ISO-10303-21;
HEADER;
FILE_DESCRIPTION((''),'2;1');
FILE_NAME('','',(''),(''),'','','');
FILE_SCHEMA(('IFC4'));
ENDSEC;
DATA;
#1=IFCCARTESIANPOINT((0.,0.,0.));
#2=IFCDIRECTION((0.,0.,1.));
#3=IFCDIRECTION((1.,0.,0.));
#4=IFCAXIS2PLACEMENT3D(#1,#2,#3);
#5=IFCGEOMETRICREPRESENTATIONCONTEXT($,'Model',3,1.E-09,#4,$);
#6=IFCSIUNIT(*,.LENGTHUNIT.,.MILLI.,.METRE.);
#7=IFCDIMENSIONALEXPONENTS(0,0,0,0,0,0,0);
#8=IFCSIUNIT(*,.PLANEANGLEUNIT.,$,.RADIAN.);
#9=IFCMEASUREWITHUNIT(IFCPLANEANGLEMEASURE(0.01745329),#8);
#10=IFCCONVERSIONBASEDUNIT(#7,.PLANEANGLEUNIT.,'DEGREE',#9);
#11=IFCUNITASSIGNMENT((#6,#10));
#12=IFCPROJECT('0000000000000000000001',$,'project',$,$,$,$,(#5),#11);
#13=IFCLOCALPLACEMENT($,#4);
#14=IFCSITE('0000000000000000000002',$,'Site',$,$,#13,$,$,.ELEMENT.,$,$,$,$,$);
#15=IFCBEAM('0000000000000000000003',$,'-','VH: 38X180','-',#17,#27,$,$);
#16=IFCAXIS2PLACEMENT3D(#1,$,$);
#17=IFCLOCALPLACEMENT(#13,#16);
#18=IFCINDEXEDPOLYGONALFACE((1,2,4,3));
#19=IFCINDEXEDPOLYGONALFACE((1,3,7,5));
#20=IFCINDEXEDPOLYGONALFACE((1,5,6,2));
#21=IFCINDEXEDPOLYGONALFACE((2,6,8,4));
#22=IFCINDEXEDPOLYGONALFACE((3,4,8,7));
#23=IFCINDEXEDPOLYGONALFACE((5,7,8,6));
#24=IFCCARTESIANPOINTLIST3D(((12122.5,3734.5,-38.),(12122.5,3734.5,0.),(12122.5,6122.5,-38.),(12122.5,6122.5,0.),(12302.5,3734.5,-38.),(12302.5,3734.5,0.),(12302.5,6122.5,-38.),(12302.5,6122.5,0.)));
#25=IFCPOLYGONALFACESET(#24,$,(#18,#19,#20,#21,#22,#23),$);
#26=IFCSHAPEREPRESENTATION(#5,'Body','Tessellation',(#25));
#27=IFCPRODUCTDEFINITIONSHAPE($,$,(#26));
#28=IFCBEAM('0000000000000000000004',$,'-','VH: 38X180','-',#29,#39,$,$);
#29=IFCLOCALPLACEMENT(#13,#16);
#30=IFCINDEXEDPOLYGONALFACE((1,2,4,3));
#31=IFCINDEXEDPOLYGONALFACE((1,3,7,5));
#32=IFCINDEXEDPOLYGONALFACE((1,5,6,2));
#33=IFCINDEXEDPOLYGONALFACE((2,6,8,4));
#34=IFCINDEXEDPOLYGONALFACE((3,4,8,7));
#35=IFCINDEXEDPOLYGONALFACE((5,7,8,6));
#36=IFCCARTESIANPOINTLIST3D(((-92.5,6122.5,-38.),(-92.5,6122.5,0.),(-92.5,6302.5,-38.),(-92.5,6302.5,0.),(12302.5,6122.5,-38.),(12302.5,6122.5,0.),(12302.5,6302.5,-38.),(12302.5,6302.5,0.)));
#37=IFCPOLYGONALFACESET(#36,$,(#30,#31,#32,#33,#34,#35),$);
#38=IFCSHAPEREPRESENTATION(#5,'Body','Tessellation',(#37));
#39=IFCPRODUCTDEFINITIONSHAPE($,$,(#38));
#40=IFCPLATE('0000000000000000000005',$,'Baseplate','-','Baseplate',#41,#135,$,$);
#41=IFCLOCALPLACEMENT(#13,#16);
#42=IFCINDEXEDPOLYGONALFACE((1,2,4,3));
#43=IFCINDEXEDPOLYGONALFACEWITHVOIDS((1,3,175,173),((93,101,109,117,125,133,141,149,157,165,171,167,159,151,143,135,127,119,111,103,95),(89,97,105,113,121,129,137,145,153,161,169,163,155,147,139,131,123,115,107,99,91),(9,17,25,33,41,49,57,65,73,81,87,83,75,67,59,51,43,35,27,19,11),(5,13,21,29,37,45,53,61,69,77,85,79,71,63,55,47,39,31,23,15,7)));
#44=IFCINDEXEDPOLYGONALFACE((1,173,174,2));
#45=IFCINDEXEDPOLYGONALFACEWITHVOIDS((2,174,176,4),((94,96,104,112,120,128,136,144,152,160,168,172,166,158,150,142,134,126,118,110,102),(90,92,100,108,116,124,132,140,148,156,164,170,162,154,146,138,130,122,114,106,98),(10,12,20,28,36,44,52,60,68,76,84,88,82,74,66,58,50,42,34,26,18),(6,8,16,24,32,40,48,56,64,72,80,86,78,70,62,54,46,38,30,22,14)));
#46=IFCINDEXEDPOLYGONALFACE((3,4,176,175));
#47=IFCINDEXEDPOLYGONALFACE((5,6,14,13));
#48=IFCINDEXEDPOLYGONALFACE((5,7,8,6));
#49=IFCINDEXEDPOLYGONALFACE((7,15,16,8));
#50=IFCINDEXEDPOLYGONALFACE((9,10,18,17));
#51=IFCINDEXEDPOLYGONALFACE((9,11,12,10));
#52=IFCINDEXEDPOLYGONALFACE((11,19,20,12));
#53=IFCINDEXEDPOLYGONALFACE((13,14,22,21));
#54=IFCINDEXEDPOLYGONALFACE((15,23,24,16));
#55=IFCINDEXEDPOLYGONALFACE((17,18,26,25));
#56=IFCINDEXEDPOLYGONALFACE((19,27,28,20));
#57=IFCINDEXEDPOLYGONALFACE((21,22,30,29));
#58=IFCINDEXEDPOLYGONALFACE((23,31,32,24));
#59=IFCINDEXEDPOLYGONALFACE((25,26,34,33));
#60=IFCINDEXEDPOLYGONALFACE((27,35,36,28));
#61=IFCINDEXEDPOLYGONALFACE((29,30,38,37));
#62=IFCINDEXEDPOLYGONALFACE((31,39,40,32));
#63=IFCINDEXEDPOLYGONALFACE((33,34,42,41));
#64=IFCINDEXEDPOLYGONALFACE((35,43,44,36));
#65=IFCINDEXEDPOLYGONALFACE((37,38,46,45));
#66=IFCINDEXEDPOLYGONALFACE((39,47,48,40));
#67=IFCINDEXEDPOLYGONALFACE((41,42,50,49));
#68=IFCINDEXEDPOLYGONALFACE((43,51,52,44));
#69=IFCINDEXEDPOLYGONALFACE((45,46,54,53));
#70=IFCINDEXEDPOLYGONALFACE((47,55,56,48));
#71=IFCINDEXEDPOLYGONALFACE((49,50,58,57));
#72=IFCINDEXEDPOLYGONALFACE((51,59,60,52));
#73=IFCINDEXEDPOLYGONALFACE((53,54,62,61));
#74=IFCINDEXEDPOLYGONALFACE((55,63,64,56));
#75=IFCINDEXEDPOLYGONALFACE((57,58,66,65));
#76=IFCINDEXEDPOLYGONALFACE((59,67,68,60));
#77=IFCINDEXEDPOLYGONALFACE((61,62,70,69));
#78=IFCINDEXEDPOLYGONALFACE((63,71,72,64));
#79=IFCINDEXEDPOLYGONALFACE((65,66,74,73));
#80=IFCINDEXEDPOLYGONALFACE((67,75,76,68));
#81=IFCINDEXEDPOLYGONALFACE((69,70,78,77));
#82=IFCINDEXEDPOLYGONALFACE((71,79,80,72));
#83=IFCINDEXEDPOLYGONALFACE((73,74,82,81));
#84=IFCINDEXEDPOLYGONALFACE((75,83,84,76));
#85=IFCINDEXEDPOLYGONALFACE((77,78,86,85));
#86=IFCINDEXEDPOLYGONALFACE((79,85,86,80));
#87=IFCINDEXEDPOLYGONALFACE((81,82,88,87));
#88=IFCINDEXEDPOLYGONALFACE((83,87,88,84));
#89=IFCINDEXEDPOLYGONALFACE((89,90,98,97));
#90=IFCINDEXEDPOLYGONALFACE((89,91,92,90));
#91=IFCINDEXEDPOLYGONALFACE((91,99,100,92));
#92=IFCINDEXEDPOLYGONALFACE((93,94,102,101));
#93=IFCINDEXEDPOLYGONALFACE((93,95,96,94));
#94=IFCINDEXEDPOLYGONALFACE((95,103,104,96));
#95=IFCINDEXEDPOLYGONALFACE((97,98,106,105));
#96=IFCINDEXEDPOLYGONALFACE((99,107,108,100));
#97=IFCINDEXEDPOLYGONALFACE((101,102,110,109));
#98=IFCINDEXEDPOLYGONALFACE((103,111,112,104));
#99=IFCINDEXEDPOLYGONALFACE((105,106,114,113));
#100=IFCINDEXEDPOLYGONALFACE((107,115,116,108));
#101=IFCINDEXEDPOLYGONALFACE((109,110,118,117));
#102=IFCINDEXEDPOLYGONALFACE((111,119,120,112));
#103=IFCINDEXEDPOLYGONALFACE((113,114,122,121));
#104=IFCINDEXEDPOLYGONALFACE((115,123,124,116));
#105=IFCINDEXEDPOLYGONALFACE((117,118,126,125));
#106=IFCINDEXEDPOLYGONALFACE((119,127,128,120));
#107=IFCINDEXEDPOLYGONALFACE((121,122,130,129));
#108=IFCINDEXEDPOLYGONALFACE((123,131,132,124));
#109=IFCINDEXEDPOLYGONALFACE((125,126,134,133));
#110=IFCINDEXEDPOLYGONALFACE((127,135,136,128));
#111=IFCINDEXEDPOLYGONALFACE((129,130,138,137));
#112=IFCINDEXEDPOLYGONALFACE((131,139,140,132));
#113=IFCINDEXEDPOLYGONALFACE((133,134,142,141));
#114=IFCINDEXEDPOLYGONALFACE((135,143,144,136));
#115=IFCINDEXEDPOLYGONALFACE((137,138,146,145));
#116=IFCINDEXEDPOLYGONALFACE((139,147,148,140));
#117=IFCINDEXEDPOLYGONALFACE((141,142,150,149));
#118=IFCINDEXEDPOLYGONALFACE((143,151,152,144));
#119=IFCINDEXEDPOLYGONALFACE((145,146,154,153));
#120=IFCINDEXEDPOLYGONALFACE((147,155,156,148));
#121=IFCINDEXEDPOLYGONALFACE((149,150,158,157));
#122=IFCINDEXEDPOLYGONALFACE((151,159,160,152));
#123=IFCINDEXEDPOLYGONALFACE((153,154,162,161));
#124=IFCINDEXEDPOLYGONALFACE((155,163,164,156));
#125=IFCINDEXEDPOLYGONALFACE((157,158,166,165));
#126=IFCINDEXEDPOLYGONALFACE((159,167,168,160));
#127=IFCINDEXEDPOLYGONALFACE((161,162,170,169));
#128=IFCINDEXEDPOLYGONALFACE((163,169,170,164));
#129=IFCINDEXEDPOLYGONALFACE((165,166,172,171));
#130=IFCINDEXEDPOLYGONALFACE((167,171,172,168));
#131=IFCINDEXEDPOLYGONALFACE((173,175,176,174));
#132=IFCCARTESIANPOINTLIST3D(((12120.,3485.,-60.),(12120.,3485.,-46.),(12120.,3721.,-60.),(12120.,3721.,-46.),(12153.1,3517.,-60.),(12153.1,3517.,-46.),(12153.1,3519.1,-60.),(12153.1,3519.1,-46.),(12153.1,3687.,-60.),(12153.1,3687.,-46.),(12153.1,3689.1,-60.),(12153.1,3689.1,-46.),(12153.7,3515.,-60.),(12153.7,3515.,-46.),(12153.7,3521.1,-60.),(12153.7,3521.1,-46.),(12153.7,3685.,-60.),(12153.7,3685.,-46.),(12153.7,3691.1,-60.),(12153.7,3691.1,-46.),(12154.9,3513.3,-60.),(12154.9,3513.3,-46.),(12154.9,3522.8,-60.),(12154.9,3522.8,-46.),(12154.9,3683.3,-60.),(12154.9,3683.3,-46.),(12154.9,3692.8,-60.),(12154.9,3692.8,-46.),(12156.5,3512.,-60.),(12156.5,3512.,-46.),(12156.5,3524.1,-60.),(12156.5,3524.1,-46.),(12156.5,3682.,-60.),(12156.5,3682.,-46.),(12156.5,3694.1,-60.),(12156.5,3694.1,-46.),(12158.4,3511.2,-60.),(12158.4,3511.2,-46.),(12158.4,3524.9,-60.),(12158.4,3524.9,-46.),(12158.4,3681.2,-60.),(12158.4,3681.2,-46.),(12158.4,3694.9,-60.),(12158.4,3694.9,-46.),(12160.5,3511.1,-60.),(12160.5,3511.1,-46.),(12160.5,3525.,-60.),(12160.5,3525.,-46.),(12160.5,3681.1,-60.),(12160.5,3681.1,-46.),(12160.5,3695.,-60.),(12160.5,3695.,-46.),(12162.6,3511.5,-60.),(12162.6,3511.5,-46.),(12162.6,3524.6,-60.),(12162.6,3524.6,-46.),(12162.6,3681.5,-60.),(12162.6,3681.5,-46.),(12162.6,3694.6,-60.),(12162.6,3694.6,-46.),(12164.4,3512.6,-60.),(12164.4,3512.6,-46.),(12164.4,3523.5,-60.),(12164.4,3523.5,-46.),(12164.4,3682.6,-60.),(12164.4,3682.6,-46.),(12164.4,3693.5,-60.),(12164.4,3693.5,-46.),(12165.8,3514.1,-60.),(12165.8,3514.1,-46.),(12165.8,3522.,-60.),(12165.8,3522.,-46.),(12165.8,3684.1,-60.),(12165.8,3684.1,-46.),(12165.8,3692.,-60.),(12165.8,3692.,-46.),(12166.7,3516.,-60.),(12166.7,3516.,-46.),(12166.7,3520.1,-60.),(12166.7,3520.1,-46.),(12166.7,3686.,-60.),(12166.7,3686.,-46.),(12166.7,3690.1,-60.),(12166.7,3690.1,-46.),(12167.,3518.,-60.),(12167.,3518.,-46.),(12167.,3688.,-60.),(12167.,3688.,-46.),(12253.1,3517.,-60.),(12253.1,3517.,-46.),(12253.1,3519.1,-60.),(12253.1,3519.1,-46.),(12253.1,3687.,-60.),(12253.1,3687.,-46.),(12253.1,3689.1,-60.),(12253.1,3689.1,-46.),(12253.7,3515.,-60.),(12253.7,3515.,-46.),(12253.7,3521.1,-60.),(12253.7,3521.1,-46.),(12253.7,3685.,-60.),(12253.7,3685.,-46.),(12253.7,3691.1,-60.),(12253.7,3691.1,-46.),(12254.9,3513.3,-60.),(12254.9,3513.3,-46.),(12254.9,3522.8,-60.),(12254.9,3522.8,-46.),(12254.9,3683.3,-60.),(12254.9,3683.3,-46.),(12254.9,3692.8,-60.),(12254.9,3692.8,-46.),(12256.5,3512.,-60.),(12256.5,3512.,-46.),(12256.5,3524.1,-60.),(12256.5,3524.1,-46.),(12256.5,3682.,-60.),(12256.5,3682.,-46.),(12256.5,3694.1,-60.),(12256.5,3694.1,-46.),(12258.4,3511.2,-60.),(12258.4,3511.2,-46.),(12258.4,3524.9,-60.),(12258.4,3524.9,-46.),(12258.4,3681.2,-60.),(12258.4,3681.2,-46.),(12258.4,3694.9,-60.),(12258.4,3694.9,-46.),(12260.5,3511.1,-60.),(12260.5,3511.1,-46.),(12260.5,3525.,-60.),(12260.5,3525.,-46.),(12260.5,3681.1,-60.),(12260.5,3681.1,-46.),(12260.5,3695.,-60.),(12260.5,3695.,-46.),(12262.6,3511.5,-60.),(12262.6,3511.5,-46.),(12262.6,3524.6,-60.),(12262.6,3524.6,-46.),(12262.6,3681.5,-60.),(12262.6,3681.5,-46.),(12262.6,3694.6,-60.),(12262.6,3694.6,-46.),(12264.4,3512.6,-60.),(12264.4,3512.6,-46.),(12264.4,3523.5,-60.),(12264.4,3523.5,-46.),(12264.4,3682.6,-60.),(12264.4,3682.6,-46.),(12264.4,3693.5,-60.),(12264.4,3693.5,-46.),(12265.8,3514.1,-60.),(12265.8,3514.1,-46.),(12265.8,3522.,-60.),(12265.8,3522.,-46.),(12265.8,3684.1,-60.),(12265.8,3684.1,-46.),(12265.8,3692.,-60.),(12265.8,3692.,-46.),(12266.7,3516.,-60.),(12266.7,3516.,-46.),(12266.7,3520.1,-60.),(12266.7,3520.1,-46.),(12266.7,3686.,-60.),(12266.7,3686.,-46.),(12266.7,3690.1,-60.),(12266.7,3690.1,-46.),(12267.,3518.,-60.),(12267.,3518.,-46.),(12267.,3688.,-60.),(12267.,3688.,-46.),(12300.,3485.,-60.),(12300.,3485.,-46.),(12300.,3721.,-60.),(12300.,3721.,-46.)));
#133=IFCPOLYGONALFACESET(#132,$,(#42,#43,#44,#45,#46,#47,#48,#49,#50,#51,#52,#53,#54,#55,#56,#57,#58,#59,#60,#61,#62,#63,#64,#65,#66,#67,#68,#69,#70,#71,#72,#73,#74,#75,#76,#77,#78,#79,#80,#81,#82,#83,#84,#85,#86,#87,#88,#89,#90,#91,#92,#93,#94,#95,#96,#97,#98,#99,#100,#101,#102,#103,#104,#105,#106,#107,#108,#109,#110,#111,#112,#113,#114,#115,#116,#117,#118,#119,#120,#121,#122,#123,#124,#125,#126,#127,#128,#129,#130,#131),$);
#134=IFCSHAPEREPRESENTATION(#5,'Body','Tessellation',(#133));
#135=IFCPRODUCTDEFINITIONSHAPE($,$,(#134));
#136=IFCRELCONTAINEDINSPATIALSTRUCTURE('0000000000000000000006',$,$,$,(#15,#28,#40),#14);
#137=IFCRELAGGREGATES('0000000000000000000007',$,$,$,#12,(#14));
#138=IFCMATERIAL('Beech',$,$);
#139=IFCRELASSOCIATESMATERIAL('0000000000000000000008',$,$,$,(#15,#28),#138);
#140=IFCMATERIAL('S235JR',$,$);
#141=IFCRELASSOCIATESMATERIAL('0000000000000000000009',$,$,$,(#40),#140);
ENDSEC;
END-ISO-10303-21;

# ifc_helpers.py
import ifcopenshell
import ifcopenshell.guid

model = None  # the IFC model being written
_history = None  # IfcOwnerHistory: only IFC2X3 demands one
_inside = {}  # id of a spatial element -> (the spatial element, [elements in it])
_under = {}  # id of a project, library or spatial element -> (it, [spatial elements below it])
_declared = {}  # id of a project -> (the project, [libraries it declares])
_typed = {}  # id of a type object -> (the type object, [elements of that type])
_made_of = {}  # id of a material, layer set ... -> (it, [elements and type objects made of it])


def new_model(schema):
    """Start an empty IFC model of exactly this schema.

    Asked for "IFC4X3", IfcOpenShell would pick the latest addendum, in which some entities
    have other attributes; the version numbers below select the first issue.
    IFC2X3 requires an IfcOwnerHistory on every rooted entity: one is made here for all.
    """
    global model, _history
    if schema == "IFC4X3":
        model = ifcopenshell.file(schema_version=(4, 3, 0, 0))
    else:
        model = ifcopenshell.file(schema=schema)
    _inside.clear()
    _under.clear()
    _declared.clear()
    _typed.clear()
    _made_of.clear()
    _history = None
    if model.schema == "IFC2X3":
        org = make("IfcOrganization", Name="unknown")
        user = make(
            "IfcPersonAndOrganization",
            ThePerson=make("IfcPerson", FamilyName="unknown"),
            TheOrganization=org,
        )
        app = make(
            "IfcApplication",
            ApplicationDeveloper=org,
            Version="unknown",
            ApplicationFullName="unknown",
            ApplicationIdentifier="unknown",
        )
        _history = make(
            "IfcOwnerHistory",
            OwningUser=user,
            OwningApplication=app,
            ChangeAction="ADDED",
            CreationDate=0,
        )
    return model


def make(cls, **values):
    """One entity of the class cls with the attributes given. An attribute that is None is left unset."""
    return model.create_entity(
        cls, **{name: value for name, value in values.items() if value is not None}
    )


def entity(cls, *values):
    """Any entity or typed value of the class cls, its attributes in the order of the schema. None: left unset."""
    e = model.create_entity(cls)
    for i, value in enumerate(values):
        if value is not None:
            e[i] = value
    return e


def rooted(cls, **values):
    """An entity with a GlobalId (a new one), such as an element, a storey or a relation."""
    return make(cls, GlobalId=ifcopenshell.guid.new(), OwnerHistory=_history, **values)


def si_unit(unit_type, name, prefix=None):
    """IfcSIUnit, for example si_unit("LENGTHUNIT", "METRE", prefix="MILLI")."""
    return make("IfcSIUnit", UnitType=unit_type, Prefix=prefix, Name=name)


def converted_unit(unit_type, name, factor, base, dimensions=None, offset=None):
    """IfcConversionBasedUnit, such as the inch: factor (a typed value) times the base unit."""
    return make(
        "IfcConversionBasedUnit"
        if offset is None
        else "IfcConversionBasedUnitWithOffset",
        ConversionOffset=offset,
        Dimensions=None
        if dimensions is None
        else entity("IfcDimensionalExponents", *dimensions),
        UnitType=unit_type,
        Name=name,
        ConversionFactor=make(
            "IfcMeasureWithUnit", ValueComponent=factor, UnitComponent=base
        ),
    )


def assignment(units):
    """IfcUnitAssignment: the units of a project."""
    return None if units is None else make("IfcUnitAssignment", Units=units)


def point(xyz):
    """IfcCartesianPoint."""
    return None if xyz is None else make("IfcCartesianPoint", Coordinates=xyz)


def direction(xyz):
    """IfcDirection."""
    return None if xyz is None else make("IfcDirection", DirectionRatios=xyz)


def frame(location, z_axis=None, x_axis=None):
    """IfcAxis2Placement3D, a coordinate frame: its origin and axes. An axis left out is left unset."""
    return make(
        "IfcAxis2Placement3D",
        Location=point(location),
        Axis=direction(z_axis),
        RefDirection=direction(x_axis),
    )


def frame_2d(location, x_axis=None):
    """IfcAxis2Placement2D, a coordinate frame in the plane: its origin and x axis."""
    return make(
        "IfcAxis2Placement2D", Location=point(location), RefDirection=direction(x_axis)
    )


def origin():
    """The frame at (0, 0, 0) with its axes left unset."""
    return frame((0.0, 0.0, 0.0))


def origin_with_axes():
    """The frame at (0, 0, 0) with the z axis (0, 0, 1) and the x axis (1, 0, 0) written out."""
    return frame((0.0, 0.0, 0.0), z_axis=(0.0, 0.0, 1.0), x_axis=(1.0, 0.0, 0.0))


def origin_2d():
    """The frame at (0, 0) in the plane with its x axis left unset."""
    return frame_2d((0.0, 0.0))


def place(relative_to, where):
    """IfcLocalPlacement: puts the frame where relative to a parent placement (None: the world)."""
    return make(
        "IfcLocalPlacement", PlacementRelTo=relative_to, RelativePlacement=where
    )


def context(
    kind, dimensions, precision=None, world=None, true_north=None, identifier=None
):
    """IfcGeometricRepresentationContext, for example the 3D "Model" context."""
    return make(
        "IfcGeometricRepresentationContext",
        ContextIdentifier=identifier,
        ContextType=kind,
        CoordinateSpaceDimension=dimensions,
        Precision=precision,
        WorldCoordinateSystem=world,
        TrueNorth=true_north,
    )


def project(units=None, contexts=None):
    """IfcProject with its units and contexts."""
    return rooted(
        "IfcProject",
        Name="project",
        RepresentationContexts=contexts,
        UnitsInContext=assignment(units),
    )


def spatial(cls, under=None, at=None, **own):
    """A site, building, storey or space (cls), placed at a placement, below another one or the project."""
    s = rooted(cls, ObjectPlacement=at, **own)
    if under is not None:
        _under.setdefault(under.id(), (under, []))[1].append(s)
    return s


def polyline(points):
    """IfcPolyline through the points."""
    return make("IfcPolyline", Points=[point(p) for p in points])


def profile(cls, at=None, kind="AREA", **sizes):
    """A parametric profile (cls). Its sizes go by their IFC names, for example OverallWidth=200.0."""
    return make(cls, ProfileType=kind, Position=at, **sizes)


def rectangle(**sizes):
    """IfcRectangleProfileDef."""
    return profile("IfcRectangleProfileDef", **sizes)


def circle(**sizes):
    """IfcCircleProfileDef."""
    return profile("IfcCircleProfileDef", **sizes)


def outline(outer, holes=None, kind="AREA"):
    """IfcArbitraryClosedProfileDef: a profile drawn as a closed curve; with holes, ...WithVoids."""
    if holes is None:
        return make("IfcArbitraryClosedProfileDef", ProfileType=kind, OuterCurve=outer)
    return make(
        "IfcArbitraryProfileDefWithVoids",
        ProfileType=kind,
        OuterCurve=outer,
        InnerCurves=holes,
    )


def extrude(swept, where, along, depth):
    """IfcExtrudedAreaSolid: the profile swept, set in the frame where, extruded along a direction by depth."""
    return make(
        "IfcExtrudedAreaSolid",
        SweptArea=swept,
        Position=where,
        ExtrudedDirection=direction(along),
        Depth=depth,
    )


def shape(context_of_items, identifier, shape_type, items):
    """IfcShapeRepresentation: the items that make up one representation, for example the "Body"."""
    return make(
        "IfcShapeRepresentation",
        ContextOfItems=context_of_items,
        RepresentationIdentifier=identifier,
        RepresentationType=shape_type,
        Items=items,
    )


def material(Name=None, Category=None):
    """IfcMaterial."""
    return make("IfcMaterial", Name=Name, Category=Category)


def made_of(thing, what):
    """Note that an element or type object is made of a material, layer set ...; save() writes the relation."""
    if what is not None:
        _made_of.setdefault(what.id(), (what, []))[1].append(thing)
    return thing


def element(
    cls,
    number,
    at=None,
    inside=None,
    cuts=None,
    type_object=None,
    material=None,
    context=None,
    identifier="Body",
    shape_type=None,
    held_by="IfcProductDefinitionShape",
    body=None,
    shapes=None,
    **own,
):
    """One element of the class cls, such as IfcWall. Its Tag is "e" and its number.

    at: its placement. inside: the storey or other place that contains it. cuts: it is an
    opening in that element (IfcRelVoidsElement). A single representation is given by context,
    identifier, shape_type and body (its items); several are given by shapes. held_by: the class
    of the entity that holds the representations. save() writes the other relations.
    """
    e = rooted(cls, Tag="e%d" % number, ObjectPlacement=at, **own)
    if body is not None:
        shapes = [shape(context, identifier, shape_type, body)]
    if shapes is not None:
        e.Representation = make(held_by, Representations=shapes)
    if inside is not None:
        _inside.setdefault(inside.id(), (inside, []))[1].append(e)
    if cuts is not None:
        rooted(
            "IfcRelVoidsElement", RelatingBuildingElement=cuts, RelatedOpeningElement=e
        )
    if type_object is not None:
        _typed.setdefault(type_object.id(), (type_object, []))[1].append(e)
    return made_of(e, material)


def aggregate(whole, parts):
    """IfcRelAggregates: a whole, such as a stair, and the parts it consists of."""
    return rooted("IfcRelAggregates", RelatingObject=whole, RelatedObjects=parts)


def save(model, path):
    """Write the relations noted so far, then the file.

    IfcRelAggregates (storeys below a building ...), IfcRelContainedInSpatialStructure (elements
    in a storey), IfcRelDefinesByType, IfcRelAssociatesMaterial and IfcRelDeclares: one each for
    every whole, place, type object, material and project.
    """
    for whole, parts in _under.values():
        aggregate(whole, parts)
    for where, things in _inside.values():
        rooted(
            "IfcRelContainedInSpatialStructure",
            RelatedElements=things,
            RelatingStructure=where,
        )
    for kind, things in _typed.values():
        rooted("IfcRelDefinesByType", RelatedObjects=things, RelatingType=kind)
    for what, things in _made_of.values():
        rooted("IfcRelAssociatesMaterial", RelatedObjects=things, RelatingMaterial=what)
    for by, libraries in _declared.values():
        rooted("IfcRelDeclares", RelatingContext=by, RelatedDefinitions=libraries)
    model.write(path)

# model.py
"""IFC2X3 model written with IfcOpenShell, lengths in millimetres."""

from ifc_helpers import new_model, entity, si_unit, converted_unit, frame, frame_2d, origin, origin_with_axes, origin_2d, place, context, project, spatial, polyline, rectangle, circle, outline, extrude, material, element, save


model = new_model("IFC2X3")

# Units and contexts
model_context = context("Model", 3, precision=1e-09, world=origin_with_axes())
ifc_project = project(units=[si_unit("LENGTHUNIT", "METRE", prefix="MILLI"), converted_unit("PLANEANGLEUNIT", "DEGREE", entity("IfcPlaneAngleMeasure", 0.01745329), si_unit("PLANEANGLEUNIT", "RADIAN"), dimensions=[0, 0, 0, 0, 0, 0, 0])], contexts=[model_context])

# Site
site_placement = place(None, origin_with_axes())
site = spatial("IfcSite", under=ifc_project, at=site_placement, Name="Site", CompositionType="ELEMENT")

# Shared definitions
ifc_material_1 = material(Name="Beech")

# Beams
beam_1_placement = place(None, frame((12212.5, 6122.5, -19.0), z_axis=(-0.000013, -1.0, 0.0), x_axis=(0.0, 0.0, 1.0)))
element("IfcBeam", 1, at=beam_1_placement, inside=site, material=ifc_material_1, Name="-", Description="VH: 38X180", ObjectType="-", context=model_context, shape_type="SweptSolid", body=[
    extrude(rectangle(XDim=38.0, YDim=180.0, at=origin_2d()), origin(), (0.0, 0.0, 1.0), 2388.0),
])
beam_2_placement = place(None, frame((12302.5, 6212.5, -19.0), z_axis=(1.0, -0.000001, 0.0), x_axis=(0.0, 0.0, -1.0)))
element("IfcBeam", 2, at=beam_2_placement, inside=site, material=ifc_material_1, Name="-", Description="VH: 38X180", ObjectType="-", context=model_context, shape_type="SweptSolid", body=[
    extrude(rectangle(XDim=38.0, YDim=180.0, at=origin_2d()), origin(), (0.0, 0.0, -1.0), 12395.0),
])

# Plate, openings
ifc_material_2 = material(Name="S235JR")
plate_placement = place(None, frame((12120.0, 3721.0, -46.0), z_axis=(0.0, 0.0, -1.0), x_axis=(1.0, 0.0, 0.0)))
plate = element("IfcPlate", 3, at=plate_placement, inside=site, material=ifc_material_2, Name="Baseplate", Description="-", ObjectType="Baseplate", context=model_context, shape_type="SweptSolid", body=[
    extrude(outline(polyline([(0.0, 0.0), (180.0, 0.0), (180.0, 236.0), (0.0, 236.0), (0.0, 0.0)])), origin_with_axes(), (0.0, 0.0, 1.0), 14.0),
])
opening_1_placement = place(plate_placement, frame((90.0, 118.0, 14.5), z_axis=(0.0, 0.0, -1.0), x_axis=(1.0, 0.0, 0.0)))
element("IfcOpeningElement", 4, at=opening_1_placement, cuts=plate, ObjectType="Opening", context=model_context, shape_type="SweptSolid", body=[
    extrude(circle(Radius=7.0, at=frame_2d((50.0, 85.0), x_axis=(1.0, 0.0))), origin(), (0.0, 0.0, 1.0), 15.0),
])
opening_2_placement = place(plate_placement, frame((90.0, 118.0, 14.5), z_axis=(0.0, 0.0, -1.0), x_axis=(1.0, 0.0, 0.0)))
element("IfcOpeningElement", 5, at=opening_2_placement, cuts=plate, ObjectType="Opening", context=model_context, shape_type="SweptSolid", body=[
    extrude(circle(Radius=7.0, at=frame_2d((-50.0, 85.0), x_axis=(1.0, 0.0))), origin(), (0.0, 0.0, 1.0), 15.0),
])
opening_3_placement = place(plate_placement, frame((90.0, 118.0, 14.5), z_axis=(0.0, 0.0, -1.0), x_axis=(1.0, 0.0, 0.0)))
element("IfcOpeningElement", 6, at=opening_3_placement, cuts=plate, ObjectType="Opening", context=model_context, shape_type="SweptSolid", body=[
    extrude(circle(Radius=7.0, at=frame_2d((50.0, -85.0), x_axis=(1.0, 0.0))), origin(), (0.0, 0.0, 1.0), 15.0),
])
opening_4_placement = place(plate_placement, frame((90.0, 118.0, 14.5), z_axis=(0.0, 0.0, -1.0), x_axis=(1.0, 0.0, 0.0)))
element("IfcOpeningElement", 7, at=opening_4_placement, cuts=plate, ObjectType="Opening", context=model_context, shape_type="SweptSolid", body=[
    extrude(circle(Radius=7.0, at=frame_2d((-50.0, -85.0), x_axis=(1.0, 0.0))), origin(), (0.0, 0.0, 1.0), 15.0),
])

save(model, "model.ifc")
